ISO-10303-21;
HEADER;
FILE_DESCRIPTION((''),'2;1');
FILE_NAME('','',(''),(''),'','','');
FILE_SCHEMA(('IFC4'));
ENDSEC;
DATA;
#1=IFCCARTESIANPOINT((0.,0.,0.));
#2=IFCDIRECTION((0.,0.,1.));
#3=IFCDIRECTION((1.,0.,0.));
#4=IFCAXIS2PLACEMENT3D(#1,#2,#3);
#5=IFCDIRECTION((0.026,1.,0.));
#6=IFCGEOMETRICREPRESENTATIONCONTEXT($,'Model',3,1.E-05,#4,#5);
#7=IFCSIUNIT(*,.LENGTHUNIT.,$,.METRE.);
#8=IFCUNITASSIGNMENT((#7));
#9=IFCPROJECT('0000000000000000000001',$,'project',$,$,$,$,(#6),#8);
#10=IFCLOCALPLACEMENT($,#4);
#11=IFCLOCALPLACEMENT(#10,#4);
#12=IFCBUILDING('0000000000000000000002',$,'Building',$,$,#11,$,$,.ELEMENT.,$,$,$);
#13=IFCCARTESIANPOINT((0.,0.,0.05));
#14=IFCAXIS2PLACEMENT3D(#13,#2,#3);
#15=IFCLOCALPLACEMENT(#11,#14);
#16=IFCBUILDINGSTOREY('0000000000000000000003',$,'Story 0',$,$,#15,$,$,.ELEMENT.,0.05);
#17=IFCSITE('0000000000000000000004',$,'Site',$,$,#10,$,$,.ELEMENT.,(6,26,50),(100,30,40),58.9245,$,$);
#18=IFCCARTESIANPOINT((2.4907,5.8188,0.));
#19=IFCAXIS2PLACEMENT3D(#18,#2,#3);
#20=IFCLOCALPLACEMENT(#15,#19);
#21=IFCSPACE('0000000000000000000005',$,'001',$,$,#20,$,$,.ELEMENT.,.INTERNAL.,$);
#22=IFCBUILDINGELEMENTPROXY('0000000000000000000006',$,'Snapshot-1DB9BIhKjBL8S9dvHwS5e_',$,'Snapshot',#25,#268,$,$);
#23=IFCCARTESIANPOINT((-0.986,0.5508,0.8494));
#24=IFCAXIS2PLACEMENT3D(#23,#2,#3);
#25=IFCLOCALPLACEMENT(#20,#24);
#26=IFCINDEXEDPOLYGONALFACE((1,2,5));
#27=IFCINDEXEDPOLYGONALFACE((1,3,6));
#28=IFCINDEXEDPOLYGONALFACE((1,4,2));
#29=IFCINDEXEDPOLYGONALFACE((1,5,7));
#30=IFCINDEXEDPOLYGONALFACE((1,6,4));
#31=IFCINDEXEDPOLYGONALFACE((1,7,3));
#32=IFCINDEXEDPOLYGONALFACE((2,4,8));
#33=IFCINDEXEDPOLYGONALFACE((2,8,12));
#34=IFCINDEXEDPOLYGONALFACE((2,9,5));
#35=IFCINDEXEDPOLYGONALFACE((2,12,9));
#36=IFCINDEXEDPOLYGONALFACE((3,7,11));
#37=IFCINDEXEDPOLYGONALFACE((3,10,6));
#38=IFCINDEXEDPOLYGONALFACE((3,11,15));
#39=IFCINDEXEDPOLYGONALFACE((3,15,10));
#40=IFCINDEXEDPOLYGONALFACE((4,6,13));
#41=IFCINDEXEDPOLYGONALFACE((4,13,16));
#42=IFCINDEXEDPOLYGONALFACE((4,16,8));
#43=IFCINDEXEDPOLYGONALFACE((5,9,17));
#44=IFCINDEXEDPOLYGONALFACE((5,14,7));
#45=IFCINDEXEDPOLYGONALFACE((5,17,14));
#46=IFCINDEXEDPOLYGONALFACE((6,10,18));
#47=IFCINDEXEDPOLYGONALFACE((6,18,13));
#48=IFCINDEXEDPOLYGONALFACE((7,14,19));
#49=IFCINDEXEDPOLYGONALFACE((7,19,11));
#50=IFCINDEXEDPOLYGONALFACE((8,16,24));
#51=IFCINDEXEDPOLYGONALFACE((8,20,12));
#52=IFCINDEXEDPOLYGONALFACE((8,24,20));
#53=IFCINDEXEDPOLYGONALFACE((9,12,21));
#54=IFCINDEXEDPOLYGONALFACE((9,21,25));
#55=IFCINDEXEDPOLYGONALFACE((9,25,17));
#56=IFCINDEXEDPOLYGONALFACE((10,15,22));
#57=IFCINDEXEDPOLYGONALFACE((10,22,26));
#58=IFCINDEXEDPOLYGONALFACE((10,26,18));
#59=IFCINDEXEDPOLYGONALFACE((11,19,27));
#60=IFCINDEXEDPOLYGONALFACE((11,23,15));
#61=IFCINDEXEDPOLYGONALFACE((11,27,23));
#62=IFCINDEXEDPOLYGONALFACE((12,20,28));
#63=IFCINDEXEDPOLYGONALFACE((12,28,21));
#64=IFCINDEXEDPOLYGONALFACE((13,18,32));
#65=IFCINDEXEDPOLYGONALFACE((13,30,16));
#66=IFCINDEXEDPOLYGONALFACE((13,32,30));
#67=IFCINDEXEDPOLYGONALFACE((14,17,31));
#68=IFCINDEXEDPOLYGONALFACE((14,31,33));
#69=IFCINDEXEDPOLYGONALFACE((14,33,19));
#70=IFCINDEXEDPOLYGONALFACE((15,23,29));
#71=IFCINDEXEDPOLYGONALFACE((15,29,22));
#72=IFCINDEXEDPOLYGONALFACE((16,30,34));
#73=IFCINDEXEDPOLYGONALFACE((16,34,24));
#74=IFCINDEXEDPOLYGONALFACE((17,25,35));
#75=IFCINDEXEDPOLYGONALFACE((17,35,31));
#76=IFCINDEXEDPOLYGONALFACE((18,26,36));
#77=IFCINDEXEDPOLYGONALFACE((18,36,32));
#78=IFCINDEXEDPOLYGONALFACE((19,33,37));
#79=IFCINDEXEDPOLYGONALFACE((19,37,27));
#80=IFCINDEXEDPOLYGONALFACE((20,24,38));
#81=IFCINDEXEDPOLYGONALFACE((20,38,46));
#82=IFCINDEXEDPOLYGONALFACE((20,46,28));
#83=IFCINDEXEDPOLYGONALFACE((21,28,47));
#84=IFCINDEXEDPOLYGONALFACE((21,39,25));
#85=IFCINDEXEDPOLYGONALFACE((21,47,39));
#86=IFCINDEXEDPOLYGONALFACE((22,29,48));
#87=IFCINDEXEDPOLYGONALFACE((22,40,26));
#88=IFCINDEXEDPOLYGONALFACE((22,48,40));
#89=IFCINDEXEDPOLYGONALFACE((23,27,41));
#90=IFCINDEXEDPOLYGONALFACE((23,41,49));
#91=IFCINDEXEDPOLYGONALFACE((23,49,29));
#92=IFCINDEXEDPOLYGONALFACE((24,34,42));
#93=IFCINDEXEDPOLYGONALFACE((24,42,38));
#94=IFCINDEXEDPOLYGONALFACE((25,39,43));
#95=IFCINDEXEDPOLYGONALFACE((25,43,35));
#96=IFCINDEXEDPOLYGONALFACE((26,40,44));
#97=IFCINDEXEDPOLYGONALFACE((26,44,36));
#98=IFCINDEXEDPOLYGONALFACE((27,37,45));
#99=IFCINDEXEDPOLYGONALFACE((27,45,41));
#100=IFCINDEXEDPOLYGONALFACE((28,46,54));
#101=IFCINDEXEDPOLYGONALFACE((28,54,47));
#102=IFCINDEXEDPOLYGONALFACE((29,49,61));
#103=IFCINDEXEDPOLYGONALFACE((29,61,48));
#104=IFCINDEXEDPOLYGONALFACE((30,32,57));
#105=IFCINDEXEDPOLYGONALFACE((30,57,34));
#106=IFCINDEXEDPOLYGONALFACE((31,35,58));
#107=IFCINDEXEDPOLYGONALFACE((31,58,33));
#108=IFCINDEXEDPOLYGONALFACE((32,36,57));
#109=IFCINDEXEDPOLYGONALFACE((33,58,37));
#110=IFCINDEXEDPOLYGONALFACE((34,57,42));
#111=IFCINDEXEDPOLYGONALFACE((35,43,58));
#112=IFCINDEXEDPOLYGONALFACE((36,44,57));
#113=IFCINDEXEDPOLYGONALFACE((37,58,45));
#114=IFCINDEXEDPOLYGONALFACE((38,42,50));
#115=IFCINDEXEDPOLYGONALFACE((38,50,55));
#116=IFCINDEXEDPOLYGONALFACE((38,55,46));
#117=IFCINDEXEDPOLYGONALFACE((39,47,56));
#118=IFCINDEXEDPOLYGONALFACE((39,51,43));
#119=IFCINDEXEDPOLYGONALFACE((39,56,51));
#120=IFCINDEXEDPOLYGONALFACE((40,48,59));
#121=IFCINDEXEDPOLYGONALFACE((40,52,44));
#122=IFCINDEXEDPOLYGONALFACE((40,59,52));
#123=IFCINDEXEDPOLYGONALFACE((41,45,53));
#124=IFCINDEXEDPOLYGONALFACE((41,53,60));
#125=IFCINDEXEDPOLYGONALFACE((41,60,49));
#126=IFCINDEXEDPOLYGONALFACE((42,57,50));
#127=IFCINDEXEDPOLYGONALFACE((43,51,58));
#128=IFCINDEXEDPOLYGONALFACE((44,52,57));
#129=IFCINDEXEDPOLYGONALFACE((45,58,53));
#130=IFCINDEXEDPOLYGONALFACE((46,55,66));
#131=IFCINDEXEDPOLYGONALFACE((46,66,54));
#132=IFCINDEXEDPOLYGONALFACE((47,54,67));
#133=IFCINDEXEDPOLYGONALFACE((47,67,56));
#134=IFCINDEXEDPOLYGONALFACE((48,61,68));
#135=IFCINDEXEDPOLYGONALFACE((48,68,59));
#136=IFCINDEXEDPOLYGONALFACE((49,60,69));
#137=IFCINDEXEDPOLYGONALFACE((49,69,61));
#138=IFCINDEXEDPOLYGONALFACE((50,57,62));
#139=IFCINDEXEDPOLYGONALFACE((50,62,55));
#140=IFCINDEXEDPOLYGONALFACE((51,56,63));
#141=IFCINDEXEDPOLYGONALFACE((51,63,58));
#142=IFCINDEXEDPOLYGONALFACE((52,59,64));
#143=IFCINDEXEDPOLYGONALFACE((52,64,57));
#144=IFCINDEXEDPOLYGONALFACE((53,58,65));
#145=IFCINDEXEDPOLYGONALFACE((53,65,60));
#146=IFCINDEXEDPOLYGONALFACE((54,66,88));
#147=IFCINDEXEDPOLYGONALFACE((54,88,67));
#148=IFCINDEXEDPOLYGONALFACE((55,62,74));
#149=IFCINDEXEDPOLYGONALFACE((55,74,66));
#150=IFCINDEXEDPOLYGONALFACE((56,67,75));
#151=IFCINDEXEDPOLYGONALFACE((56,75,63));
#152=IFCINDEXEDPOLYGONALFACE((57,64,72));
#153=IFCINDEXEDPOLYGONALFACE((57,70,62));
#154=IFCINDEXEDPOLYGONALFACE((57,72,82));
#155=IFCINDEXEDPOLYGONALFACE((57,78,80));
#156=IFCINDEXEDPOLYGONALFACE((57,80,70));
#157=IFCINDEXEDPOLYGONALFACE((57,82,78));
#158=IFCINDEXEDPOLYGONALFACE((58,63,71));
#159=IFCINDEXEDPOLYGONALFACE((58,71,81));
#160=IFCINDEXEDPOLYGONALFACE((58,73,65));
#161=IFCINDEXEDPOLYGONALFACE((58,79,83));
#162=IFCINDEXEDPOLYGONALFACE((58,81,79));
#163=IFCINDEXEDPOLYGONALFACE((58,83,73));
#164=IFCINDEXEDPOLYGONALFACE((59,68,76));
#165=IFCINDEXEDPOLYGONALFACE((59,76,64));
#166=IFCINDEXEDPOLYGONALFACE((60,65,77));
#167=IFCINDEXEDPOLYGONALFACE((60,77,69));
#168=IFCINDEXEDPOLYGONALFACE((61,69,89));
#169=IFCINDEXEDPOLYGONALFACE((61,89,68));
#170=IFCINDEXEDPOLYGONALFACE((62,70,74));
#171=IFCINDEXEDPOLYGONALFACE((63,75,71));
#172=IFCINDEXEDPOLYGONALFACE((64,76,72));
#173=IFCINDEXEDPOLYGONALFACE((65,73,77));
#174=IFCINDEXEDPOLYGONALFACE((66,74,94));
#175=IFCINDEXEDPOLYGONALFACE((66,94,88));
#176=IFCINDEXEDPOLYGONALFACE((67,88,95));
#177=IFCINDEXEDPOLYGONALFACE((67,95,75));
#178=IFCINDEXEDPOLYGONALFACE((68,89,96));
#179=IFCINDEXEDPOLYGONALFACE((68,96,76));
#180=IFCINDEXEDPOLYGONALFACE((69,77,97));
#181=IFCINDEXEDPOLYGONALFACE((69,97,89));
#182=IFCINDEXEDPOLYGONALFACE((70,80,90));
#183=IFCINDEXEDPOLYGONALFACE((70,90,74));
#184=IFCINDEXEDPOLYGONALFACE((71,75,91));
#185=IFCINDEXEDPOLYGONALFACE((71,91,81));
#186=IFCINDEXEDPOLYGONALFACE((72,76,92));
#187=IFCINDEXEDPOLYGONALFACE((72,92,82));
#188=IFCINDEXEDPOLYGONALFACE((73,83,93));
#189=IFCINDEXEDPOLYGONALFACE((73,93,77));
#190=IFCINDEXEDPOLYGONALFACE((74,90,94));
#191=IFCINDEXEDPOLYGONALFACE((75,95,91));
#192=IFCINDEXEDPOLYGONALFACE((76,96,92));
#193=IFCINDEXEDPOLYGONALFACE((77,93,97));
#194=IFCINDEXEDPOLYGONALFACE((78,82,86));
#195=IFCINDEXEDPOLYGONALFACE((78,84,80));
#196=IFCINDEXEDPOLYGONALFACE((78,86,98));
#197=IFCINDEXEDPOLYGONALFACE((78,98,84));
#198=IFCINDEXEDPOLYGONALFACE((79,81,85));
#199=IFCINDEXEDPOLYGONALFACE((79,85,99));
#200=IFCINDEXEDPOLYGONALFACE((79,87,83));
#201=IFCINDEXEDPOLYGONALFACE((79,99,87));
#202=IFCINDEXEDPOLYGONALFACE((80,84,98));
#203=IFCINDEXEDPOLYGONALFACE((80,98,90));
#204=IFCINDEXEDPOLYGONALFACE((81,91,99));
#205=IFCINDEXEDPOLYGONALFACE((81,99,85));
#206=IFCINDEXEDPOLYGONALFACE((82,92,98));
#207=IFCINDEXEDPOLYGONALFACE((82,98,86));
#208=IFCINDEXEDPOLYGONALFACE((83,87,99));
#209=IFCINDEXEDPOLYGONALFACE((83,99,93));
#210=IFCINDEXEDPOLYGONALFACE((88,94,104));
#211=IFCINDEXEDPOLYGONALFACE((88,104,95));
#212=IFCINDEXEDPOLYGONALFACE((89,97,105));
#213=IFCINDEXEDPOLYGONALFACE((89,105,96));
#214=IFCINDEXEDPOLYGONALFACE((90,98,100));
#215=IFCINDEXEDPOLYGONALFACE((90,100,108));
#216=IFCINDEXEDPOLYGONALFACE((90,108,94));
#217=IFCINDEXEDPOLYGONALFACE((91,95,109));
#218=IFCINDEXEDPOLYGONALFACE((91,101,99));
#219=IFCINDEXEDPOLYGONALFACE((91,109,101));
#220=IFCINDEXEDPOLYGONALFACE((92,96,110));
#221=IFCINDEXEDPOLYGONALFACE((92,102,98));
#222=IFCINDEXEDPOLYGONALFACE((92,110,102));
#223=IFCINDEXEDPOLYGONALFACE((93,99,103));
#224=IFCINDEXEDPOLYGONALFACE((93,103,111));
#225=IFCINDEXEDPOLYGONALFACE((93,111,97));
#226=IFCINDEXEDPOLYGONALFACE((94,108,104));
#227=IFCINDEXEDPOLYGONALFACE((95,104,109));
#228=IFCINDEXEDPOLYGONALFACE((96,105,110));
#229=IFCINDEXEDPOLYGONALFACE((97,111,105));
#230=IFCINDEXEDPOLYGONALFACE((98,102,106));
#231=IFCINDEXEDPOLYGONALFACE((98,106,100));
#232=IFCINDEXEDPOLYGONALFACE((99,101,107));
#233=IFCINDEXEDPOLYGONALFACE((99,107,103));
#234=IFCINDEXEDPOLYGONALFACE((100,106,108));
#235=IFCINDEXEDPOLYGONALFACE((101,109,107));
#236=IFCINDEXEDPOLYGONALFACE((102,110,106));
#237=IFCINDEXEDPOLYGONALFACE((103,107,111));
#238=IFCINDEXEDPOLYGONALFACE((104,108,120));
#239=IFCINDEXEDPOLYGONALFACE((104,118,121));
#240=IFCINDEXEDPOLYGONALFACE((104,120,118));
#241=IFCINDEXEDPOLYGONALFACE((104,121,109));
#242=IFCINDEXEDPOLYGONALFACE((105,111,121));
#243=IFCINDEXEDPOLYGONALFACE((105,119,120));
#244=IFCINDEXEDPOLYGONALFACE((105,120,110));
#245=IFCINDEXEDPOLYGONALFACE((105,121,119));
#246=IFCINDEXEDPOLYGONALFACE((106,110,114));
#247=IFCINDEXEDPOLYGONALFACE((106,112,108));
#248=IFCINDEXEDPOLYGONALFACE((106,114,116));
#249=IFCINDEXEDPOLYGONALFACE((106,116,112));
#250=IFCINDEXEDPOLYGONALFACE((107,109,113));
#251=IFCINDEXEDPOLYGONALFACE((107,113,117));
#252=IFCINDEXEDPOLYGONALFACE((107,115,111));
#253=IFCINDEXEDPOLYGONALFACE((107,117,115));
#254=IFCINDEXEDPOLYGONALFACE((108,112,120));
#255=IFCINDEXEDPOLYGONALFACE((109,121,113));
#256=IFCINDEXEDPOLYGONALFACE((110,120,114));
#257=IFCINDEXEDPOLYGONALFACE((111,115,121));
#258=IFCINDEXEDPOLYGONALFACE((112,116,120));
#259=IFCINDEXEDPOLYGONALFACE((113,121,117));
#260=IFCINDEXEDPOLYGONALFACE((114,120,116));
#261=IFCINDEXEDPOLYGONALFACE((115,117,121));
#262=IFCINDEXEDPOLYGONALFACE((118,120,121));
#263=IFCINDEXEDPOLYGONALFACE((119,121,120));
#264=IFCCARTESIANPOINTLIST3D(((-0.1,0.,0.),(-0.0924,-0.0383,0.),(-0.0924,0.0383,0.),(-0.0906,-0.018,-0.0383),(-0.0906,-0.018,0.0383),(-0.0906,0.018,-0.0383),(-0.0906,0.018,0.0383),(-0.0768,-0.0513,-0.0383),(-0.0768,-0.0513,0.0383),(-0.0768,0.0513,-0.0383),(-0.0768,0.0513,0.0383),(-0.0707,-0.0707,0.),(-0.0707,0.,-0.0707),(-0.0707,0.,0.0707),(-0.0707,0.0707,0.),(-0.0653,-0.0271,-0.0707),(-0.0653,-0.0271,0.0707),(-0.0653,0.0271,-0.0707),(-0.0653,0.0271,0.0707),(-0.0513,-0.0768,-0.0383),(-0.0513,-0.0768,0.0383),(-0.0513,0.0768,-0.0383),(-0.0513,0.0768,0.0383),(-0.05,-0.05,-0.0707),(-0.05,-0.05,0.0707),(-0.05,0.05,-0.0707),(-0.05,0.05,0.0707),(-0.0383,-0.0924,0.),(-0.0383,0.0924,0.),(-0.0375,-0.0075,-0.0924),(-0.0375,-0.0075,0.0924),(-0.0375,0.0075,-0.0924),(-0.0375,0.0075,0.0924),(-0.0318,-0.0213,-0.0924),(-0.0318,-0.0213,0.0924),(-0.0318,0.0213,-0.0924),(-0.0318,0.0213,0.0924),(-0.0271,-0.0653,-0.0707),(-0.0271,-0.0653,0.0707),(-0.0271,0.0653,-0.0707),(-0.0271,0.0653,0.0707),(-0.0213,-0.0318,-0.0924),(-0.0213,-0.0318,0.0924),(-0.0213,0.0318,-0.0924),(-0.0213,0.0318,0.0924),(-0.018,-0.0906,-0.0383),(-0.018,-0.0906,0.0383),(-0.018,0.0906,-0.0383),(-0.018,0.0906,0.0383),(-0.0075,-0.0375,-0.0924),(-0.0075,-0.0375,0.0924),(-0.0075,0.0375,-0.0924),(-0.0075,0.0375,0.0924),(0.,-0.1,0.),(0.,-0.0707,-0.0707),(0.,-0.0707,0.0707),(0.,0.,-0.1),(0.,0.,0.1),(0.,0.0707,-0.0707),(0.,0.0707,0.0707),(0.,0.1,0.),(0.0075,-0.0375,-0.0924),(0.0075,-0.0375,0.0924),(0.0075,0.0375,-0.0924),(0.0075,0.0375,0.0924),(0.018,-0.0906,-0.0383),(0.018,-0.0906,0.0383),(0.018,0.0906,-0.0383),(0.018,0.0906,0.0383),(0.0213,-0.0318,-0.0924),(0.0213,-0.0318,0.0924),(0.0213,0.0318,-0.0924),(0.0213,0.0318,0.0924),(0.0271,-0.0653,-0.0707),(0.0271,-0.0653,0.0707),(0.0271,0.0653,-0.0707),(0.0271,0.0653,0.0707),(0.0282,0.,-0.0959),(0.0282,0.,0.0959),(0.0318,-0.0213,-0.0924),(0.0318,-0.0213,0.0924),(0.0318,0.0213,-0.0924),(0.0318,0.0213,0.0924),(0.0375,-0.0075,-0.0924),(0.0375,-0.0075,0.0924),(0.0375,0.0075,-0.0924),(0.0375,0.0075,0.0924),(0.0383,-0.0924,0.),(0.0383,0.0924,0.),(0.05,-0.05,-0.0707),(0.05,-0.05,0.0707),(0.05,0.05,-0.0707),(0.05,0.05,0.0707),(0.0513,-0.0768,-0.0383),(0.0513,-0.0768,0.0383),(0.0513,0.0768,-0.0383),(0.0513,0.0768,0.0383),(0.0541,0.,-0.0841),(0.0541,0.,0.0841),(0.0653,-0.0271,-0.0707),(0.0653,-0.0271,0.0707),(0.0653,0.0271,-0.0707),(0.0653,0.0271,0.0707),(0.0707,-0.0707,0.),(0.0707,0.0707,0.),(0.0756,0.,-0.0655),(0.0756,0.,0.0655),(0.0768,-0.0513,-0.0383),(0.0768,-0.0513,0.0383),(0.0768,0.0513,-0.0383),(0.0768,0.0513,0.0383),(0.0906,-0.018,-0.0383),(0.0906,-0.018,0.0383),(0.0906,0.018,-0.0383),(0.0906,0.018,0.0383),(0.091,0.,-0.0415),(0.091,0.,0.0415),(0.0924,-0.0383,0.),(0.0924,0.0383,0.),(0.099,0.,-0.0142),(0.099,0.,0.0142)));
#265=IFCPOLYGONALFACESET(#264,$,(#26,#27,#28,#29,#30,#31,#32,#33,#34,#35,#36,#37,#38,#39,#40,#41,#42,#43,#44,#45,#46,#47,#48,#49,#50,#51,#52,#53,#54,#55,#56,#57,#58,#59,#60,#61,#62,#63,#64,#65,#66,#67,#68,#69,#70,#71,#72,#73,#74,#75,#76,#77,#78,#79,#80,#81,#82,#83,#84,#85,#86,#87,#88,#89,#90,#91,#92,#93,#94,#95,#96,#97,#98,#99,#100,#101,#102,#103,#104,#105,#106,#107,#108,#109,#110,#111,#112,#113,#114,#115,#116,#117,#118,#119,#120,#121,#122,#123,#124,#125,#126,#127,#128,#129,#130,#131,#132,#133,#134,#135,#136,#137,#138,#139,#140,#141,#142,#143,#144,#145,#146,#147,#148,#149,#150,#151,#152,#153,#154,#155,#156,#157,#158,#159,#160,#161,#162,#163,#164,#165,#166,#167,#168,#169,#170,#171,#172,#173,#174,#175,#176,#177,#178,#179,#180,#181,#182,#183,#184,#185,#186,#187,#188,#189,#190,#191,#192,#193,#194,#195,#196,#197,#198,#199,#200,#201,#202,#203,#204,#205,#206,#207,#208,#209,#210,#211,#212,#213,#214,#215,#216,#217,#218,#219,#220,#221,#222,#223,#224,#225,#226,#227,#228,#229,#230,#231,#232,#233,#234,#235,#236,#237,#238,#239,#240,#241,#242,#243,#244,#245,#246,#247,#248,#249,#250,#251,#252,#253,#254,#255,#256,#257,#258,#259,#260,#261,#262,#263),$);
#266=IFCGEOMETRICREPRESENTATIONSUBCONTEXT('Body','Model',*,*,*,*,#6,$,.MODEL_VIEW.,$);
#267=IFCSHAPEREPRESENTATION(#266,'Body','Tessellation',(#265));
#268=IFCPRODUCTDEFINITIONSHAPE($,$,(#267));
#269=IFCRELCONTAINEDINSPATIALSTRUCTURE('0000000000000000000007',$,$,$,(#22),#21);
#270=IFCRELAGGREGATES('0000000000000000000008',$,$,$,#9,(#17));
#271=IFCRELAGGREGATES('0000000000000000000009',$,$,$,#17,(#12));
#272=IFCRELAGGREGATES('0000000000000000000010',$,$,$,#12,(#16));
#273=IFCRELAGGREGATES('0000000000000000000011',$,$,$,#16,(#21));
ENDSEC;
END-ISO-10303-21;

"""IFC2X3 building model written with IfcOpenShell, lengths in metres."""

from ifc_helpers import new_model, entity, si_unit, direction, frame, origin_with_axes, place, context, subcontext, project, spatial, element, save


model = new_model("IFC2X3")

# Units and contexts
model_context = context("Model", 3, precision=1e-05, world=origin_with_axes(), true_north=direction((0.026, 1.0, 0.0)))
body_context = subcontext(model_context, "Body", "Model", "MODEL_VIEW")
ifc_project = project(units=[si_unit("LENGTHUNIT", "METRE")], contexts=[model_context])

# Site, building, storey
site_placement = place(None, origin_with_axes())
site = spatial("IfcSite", under=ifc_project, at=site_placement, Name="Site", CompositionType="ELEMENT", RefLatitude=(6, 26, 50), RefLongitude=(100, 30, 40), RefElevation=58.9245)
building_placement = place(site_placement, origin_with_axes())
building = spatial("IfcBuilding", under=site, at=building_placement, Name="Building", CompositionType="ELEMENT")
storey_placement = place(building_placement, frame((0.0, 0.0, 0.05), z_axis=(0.0, 0.0, 1.0), x_axis=(1.0, 0.0, 0.0)))
storey = spatial("IfcBuildingStorey", under=building, at=storey_placement, Name="Story 0", CompositionType="ELEMENT", Elevation=0.05)

# Shared definitions
space_placement = place(storey_placement, frame((2.4907, 5.8188, 0.0), z_axis=(0.0, 0.0, 1.0), x_axis=(1.0, 0.0, 0.0)))
space = spatial("IfcSpace", under=storey, at=space_placement, Name="001", CompositionType="ELEMENT", InteriorOrExteriorSpace="INTERNAL")

# Building element proxy
for number, where, z_axis, x_axis, name in (
    (1, (-0.986, 0.5508, 0.8494), (0.0, 0.0, 1.0), (1.0, 0.0, 0.0), "Snapshot-1DB9BIhKjBL8S9dvHwS5e_"),
):
    element("IfcBuildingElementProxy", number, at=place(space_placement, frame(where, z_axis=z_axis, x_axis=x_axis)), inside=space, Name=name, ObjectType="Snapshot", context=body_context, shape_type="CSG", body=[
        entity("IfcSphere", entity("IfcAxis2Placement3D", entity("IfcCartesianPoint", [0.0, 0.0, 0.0]), entity("IfcDirection", [0.0, 0.0, 1.0]), entity("IfcDirection", [1.0, 0.0, 0.0])), 0.1),
    ])

save(model, "model.ifc")
